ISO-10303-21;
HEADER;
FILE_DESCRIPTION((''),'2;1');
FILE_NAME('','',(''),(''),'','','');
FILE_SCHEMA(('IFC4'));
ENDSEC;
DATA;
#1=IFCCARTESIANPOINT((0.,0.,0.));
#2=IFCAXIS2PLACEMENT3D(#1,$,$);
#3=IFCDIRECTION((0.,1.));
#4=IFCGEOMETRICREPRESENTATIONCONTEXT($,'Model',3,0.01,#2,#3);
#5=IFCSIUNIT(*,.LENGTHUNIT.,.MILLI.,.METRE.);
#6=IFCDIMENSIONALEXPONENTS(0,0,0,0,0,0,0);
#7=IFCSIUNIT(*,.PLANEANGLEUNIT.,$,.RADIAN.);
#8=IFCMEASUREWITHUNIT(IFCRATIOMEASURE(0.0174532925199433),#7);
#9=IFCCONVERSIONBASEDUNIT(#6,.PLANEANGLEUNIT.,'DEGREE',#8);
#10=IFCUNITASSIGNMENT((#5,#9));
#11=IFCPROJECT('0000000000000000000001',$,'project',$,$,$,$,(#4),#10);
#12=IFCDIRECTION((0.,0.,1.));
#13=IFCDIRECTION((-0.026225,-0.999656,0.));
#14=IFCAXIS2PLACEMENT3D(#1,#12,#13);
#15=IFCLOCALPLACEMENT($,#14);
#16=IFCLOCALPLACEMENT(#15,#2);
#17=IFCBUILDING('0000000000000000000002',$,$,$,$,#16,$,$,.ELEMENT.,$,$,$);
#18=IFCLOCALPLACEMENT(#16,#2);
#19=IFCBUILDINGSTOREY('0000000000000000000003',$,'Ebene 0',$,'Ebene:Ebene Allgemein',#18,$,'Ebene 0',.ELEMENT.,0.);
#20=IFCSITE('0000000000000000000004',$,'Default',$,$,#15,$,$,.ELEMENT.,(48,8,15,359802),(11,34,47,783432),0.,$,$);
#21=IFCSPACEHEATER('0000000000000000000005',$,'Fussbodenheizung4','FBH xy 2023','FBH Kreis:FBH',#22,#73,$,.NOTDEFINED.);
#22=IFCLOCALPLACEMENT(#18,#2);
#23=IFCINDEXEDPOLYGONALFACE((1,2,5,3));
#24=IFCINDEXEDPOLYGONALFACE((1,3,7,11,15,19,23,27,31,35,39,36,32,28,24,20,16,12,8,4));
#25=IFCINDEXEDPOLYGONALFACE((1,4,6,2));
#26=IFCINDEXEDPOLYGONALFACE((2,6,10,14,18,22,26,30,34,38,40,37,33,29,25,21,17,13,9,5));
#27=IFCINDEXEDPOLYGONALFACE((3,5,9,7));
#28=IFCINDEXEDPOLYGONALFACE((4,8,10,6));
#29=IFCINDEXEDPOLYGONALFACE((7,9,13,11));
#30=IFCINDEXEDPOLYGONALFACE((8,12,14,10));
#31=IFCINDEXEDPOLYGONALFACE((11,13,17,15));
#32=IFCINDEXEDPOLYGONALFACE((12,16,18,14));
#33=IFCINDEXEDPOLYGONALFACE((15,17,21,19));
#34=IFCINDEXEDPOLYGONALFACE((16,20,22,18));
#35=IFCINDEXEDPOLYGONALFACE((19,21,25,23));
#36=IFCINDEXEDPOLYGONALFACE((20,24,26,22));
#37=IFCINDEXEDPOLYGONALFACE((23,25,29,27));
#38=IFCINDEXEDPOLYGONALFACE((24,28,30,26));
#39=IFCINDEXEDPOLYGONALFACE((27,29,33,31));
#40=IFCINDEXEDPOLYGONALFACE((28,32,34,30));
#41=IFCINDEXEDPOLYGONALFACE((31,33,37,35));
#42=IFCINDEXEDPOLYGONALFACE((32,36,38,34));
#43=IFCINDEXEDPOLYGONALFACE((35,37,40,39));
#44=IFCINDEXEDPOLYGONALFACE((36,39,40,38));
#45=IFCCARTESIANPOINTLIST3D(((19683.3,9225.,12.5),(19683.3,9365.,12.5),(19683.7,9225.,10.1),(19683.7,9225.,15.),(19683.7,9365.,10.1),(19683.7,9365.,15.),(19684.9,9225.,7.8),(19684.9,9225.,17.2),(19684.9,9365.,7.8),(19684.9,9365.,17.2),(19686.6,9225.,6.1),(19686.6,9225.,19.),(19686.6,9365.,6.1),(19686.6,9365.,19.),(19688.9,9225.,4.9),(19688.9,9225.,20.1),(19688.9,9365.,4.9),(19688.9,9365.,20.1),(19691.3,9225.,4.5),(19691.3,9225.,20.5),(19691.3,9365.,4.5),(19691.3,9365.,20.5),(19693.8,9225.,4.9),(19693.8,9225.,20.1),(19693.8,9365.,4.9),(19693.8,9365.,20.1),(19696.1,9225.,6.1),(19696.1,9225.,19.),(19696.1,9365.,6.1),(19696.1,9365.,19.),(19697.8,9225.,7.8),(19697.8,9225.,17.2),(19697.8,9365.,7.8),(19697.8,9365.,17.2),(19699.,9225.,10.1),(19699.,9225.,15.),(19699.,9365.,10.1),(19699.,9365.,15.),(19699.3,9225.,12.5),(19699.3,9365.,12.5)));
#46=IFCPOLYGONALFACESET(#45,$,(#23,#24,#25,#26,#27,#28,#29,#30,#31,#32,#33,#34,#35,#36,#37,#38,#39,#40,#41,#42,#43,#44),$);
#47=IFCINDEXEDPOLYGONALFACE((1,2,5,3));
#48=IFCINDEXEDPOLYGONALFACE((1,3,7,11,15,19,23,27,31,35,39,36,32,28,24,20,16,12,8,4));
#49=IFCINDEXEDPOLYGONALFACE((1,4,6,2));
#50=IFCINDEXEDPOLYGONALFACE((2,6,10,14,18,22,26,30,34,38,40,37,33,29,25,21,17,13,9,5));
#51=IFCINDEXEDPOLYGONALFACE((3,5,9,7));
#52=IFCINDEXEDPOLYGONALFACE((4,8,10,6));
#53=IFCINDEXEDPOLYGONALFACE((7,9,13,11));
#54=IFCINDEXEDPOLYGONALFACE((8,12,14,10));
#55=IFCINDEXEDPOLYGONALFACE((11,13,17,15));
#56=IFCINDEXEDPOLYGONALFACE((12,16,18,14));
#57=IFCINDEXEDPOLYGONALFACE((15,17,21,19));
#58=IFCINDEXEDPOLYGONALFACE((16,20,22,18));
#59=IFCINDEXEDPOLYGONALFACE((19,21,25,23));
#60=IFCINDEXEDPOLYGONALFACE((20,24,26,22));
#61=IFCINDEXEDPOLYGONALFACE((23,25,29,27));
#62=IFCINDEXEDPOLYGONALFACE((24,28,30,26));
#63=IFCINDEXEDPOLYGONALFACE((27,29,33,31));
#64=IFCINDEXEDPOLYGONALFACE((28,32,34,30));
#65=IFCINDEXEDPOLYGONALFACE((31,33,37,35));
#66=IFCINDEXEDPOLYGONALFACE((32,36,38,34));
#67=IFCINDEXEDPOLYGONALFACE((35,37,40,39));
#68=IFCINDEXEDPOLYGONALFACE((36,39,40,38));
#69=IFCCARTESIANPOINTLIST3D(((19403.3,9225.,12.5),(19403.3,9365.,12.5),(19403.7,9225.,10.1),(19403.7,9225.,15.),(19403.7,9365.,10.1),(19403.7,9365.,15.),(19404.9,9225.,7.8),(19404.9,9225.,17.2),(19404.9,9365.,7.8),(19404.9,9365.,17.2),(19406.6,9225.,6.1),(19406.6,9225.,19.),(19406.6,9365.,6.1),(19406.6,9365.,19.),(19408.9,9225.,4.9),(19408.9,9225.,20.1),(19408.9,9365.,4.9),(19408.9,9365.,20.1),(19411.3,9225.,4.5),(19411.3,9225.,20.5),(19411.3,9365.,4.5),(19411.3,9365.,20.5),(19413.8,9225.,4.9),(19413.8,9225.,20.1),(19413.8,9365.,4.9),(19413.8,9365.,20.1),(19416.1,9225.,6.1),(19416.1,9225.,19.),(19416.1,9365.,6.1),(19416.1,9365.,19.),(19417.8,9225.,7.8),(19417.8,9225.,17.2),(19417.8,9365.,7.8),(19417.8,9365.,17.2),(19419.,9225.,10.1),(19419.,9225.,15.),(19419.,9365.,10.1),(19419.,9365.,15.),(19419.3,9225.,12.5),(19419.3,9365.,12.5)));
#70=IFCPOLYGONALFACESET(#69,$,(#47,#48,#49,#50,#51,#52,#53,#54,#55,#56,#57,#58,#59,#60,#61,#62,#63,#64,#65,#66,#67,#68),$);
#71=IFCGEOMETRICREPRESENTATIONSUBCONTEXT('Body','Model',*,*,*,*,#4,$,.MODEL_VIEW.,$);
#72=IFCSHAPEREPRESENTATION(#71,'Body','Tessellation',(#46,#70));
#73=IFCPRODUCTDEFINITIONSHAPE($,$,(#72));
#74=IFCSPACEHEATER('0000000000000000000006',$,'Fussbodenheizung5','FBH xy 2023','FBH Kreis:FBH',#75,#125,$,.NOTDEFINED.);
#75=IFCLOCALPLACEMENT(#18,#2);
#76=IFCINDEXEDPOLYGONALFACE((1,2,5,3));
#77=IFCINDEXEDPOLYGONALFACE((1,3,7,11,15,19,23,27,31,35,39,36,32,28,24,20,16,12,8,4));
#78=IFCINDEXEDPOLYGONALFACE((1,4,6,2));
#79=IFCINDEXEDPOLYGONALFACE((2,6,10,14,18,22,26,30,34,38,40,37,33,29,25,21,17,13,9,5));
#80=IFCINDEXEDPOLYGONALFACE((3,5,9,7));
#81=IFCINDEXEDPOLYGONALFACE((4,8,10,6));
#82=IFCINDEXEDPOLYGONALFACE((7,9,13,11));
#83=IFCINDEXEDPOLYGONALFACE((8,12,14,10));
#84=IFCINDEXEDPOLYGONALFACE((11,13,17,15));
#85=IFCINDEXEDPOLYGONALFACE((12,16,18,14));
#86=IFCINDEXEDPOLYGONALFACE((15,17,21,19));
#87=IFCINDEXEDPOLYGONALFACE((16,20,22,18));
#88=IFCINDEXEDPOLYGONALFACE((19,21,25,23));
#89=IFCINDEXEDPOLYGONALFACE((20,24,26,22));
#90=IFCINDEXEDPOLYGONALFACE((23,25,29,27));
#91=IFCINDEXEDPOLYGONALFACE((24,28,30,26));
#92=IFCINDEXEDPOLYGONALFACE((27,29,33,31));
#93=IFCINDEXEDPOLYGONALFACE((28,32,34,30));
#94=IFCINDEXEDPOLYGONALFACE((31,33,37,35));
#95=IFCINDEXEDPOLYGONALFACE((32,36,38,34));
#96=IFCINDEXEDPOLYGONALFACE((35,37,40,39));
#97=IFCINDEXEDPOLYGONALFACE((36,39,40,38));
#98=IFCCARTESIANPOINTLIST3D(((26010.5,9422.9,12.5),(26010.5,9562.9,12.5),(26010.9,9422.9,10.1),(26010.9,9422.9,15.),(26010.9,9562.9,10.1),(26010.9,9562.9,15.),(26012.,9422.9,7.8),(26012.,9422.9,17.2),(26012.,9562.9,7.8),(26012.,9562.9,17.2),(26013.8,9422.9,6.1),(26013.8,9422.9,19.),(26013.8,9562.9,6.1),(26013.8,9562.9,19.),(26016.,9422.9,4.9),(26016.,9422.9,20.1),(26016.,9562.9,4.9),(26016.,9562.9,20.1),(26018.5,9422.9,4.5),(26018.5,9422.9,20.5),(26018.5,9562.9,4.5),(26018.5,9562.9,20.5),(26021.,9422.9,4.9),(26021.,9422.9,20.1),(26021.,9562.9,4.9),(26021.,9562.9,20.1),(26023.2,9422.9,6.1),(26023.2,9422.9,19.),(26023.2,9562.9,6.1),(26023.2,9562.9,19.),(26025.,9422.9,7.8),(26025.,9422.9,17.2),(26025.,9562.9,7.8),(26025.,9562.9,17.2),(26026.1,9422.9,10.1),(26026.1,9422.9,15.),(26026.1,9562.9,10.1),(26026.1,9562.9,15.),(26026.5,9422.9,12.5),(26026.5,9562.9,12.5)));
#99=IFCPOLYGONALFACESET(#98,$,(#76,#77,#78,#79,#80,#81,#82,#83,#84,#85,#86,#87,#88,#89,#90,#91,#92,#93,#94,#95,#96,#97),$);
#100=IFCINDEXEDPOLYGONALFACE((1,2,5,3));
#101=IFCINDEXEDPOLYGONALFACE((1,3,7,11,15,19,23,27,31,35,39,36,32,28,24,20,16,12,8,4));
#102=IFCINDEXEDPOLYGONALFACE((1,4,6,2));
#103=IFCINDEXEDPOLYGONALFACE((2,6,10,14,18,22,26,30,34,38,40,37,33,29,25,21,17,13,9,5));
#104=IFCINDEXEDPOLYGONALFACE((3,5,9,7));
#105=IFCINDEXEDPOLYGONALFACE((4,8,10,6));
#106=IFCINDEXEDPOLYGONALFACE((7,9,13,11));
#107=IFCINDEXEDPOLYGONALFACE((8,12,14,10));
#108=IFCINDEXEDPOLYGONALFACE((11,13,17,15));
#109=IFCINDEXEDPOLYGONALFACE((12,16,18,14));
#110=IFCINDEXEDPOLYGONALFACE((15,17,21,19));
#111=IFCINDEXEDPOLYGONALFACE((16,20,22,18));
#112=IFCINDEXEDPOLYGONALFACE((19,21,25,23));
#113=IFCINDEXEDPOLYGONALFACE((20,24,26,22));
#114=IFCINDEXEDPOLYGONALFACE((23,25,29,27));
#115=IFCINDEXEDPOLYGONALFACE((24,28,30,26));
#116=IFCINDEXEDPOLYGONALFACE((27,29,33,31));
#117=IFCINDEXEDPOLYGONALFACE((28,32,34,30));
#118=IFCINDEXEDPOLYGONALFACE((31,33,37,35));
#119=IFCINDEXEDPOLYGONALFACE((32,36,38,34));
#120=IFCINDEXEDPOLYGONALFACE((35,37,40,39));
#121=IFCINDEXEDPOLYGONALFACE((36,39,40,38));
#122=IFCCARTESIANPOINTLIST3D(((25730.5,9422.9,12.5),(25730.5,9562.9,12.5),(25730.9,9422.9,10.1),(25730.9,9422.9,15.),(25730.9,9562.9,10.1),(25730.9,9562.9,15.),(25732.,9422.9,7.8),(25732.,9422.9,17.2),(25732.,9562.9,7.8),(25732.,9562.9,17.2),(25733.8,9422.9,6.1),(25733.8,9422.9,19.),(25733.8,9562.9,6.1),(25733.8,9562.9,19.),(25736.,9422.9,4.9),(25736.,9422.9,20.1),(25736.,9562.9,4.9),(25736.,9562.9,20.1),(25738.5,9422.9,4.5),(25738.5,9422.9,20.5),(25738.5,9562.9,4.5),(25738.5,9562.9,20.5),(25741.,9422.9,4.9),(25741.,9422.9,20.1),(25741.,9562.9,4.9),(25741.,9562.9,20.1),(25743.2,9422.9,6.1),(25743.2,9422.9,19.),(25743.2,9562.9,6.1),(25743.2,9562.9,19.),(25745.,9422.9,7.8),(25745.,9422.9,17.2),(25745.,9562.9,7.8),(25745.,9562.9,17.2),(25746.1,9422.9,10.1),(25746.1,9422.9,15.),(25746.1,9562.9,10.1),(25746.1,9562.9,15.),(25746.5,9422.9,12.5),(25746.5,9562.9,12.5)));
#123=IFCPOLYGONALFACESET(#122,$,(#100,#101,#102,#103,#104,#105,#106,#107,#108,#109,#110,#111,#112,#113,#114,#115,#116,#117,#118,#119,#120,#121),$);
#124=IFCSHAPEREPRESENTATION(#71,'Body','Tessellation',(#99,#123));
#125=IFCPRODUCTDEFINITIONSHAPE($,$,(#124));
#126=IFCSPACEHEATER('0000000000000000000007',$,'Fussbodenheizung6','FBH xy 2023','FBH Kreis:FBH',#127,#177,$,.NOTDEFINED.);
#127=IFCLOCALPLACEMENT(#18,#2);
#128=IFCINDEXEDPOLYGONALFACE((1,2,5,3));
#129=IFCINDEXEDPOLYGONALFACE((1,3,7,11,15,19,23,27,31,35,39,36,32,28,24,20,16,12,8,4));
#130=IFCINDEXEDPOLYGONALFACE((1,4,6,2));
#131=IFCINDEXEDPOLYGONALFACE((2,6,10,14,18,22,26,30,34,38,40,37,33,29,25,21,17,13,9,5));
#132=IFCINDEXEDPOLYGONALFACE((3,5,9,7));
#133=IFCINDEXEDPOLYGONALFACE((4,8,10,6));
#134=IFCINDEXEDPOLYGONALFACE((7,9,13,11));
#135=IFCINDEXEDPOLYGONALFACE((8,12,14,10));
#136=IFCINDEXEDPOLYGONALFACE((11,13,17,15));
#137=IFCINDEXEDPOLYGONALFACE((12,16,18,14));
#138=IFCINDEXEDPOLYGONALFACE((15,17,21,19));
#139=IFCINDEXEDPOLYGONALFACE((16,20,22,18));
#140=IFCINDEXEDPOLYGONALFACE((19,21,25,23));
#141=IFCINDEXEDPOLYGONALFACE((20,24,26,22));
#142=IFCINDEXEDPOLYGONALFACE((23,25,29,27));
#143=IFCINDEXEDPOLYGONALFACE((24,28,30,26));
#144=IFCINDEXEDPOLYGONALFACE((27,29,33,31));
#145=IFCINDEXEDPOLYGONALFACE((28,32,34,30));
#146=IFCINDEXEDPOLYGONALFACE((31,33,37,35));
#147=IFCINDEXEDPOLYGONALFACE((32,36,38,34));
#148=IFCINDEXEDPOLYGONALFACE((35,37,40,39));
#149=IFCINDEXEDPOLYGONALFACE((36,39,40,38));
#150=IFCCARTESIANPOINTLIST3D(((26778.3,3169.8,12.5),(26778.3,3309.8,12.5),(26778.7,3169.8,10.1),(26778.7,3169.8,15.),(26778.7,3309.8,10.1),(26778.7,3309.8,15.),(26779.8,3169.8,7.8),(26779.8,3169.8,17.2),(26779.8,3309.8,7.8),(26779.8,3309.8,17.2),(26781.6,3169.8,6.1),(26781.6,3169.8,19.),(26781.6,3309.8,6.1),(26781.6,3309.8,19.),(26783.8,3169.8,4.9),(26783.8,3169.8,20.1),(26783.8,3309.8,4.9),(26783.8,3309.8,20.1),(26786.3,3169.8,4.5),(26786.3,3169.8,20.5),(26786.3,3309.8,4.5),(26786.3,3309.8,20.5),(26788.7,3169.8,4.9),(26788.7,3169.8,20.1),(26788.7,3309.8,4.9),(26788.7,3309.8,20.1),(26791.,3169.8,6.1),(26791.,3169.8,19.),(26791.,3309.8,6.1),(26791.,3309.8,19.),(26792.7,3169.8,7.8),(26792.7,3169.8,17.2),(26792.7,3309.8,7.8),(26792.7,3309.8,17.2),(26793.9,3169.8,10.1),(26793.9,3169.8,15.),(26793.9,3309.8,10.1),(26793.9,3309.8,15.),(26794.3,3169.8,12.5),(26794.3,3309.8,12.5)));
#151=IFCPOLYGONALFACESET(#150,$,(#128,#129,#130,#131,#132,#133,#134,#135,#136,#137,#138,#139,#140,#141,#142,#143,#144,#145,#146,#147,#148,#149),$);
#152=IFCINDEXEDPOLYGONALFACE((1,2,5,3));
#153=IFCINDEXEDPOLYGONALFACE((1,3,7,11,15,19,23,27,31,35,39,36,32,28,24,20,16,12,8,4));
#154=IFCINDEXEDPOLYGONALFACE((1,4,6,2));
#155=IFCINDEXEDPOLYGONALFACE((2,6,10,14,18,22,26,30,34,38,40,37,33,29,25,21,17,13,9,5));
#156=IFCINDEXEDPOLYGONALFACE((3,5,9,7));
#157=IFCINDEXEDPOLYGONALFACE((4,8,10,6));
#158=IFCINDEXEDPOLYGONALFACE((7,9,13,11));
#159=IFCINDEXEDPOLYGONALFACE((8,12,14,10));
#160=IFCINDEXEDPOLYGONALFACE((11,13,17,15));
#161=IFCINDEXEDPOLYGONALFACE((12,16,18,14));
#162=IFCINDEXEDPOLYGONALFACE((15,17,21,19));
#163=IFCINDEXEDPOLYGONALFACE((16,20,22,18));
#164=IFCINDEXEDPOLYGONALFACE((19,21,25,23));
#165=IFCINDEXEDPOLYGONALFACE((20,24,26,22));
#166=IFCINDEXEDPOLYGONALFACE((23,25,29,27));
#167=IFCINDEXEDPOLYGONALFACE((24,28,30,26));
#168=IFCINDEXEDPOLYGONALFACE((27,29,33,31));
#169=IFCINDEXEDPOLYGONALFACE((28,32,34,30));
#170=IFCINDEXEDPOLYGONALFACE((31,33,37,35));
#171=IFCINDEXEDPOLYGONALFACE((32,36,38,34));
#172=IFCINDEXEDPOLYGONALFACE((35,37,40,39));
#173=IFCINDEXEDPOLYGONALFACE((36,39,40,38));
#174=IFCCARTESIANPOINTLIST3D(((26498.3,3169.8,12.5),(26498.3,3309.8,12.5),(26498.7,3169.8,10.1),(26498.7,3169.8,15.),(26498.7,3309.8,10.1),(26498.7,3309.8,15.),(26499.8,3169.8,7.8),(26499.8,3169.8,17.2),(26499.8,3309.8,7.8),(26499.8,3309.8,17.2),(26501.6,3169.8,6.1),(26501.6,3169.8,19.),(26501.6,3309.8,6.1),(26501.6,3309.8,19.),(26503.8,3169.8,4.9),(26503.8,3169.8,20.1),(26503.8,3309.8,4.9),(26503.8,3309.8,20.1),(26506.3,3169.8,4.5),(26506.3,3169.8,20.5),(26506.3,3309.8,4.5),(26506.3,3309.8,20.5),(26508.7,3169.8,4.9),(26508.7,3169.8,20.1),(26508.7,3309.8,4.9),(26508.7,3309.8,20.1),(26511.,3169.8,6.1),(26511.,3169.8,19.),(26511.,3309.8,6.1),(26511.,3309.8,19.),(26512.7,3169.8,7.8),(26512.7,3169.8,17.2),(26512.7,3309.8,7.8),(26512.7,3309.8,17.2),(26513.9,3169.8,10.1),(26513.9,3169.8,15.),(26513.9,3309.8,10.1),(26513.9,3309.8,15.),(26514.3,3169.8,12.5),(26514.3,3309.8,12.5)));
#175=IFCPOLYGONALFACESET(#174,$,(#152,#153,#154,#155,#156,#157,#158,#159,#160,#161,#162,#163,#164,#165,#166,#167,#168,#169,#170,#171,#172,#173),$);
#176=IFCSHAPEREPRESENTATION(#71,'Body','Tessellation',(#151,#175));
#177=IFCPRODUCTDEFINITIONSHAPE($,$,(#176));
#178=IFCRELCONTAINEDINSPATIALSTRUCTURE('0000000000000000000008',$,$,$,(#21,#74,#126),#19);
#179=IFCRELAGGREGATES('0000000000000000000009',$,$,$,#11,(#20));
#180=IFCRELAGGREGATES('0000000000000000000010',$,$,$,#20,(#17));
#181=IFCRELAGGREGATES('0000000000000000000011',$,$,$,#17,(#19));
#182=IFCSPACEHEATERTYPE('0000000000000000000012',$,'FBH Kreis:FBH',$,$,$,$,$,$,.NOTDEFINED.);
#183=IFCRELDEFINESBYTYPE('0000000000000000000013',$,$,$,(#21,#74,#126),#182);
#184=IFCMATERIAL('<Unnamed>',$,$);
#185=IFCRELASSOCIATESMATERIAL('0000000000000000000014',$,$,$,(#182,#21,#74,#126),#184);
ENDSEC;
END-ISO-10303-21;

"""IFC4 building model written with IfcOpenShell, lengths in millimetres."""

from ifc_helpers import new_model, entity, si_unit, converted_unit, direction, frame, origin, place, context, subcontext, project, spatial, indexed_curve, outline, extrude, source, transform, mapped, material, type_object, type_shapes, element, save


model = new_model("IFC4")

# Units and contexts
model_context = context("Model", 3, precision=0.01, world=origin(), true_north=direction((0.0, 1.0)))
body_context = subcontext(model_context, "Body", "Model", "MODEL_VIEW")
ifc_project = project(units=[si_unit("LENGTHUNIT", "METRE", prefix="MILLI"), converted_unit("PLANEANGLEUNIT", "DEGREE", entity("IfcRatioMeasure", 0.0174532925199433), si_unit("PLANEANGLEUNIT", "RADIAN"), dimensions=[0, 0, 0, 0, 0, 0, 0])], contexts=[model_context])

# Site, building, storey
site_placement = place(None, frame((0.0, 0.0, 0.0), z_axis=(0.0, 0.0, 1.0), x_axis=(-0.026225, -0.999656, 0.0)))
site = spatial("IfcSite", under=ifc_project, at=site_placement, Name="Default", CompositionType="ELEMENT", RefLatitude=(48, 8, 15, 359802), RefLongitude=(11, 34, 47, 783432), RefElevation=0.0)
building_placement = place(site_placement, origin())
building = spatial("IfcBuilding", under=site, at=building_placement, CompositionType="ELEMENT")
storey_placement = place(building_placement, origin())
storey = spatial("IfcBuildingStorey", under=building, at=storey_placement, Name="Ebene 0", ObjectType="Ebene:Ebene Allgemein", LongName="Ebene 0", CompositionType="ELEMENT", Elevation=0.0)

# Space heaters
ifc_material = material(Name="<Unnamed>")
space_heater_type = type_object("IfcSpaceHeaterType", Name="FBH Kreis:FBH", PredefinedType="NOTDEFINED", material=ifc_material)
shared_shape = source(origin(), body_context, "Body", "SweptSolid", [
    extrude(outline(indexed_curve([(8.0, 0.0), (7.6, 2.5), (6.5, 4.7), (4.7, 6.5), (2.5, 7.6), (0.0, 8.0), (-2.5, 7.6), (-4.7, 6.5), (-6.5, 4.7), (-7.6, 2.5), (-8.0, 0.0), (-7.6, -2.5), (-6.5, -4.7), (-4.7, -6.5), (-2.5, -7.6), (0.0, -8.0), (2.5, -7.6), (4.7, -6.5), (6.5, -4.7), (7.6, -2.5), (8.0, 0.0)], self_intersect=False)), frame((140.0, -1621.8, -83.0), z_axis=(0.0, 1.0, 0.0), x_axis=(1.0, 0.0, 0.0)), (0.0, 0.0, 1.0), 140.0),
    extrude(outline(indexed_curve([(8.0, 0.0), (7.6, 2.5), (6.5, 4.7), (4.7, 6.5), (2.5, 7.6), (0.0, 8.0), (-2.5, 7.6), (-4.7, 6.5), (-6.5, 4.7), (-7.6, 2.5), (-8.0, 0.0), (-7.6, -2.5), (-6.5, -4.7), (-4.7, -6.5), (-2.5, -7.6), (0.0, -8.0), (2.5, -7.6), (4.7, -6.5), (6.5, -4.7), (7.6, -2.5), (8.0, 0.0)], self_intersect=False)), frame((-140.0, -1621.8, -83.0), z_axis=(0.0, 1.0, 0.0), x_axis=(1.0, 0.0, 0.0)), (0.0, 0.0, 1.0), 140.0),
])
type_shapes(space_heater_type, [shared_shape])
for number, where, name in (
    (1, (19551.3, 10846.8, 95.5), "Fussbodenheizung4"),
    (2, (25878.5, 11044.6, 95.5), "Fussbodenheizung5"),
    (3, (26646.3, 4791.6, 95.5), "Fussbodenheizung6"),
):
    element("IfcSpaceHeater", number, at=place(storey_placement, frame(where)), inside=storey, type_object=space_heater_type, material=ifc_material, Name=name, Description="FBH xy 2023", ObjectType="FBH Kreis:FBH", PredefinedType="NOTDEFINED", context=body_context, shape_type="MappedRepresentation", body=[
        mapped(shared_shape, transform((0.0, 0.0, 0.0), scale=1.0)),
    ])

save(model, "model.ifc")
